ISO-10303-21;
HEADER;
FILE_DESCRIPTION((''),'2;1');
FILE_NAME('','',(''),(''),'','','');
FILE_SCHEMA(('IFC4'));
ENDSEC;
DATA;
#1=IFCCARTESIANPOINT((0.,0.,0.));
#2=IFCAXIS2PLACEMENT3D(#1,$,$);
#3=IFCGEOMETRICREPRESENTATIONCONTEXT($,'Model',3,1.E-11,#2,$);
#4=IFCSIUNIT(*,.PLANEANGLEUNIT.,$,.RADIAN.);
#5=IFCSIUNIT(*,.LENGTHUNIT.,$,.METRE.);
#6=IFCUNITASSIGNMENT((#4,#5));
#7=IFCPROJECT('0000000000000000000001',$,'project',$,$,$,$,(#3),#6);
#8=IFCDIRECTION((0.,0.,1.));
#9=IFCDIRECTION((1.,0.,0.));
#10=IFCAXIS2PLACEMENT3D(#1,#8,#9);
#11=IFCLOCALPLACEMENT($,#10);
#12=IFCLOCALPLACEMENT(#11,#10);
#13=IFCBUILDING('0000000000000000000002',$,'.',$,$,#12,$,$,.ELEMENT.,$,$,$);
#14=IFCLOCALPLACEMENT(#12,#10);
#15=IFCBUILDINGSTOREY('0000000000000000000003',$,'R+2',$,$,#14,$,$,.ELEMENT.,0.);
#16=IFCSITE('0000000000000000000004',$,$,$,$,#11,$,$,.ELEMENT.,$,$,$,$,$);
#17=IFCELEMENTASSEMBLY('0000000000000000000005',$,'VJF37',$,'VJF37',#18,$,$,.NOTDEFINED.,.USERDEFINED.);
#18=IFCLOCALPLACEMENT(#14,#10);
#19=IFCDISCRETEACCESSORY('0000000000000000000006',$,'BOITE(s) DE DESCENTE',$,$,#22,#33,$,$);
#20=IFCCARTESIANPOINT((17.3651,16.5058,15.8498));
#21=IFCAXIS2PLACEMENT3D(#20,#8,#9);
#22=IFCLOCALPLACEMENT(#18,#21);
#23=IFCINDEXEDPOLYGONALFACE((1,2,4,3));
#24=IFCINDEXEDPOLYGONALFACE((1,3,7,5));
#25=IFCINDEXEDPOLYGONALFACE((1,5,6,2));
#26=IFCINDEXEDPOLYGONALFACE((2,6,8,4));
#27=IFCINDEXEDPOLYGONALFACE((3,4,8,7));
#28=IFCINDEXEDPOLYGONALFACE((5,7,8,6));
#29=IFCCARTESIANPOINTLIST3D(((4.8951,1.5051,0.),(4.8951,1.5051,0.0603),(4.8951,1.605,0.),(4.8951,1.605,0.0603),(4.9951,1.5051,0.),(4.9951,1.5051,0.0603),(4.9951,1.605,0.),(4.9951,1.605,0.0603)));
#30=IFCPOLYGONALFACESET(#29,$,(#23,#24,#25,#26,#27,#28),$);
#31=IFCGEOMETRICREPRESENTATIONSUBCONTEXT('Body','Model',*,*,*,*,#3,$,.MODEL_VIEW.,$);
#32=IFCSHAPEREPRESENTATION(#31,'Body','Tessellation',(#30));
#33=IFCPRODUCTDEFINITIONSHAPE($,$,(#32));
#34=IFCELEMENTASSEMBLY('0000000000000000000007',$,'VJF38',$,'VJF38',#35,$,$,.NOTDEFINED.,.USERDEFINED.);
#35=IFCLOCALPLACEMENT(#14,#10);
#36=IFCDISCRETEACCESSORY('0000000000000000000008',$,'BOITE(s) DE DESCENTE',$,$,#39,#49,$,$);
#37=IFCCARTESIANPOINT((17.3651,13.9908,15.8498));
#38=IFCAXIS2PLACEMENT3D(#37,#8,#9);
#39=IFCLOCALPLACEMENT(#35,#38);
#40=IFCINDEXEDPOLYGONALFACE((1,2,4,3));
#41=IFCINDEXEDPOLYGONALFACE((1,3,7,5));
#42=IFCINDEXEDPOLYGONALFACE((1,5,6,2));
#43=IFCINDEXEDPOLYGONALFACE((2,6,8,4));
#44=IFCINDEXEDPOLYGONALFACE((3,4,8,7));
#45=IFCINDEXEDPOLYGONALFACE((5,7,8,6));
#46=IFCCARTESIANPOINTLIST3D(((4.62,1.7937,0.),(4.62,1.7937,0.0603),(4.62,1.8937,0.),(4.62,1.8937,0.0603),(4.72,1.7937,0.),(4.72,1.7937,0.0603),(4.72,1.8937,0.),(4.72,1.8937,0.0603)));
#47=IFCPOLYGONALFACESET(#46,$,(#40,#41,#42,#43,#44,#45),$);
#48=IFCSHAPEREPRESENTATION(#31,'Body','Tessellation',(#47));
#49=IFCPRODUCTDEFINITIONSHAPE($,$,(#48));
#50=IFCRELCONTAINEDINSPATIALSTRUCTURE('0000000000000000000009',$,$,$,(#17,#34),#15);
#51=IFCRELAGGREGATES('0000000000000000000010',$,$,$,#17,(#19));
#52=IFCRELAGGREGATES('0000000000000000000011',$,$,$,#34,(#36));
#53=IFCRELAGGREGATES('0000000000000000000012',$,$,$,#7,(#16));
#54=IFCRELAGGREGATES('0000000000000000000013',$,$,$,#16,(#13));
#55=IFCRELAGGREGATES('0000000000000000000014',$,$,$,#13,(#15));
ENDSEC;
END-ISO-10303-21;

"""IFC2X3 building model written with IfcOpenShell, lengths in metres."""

from ifc_helpers import new_model, si_unit, frame, origin, origin_with_axes, place, context, subcontext, project, spatial, polyline, outline, extrude, element, aggregate, save


model = new_model("IFC2X3")

# Units and contexts
model_context = context("Model", 3, precision=1e-11, world=origin())
body_context = subcontext(model_context, "Body", "Model", "MODEL_VIEW")
ifc_project = project(units=[si_unit("PLANEANGLEUNIT", "RADIAN"), si_unit("LENGTHUNIT", "METRE")], contexts=[model_context])

# Site, building, storey
site_placement = place(None, origin_with_axes())
site = spatial("IfcSite", under=ifc_project, at=site_placement, CompositionType="ELEMENT")
building_placement = place(site_placement, origin_with_axes())
building = spatial("IfcBuilding", under=site, at=building_placement, Name=".", CompositionType="ELEMENT")
storey_placement = place(building_placement, origin_with_axes())
storey = spatial("IfcBuildingStorey", under=building, at=storey_placement, Name="R+2", CompositionType="ELEMENT", Elevation=0.0)

# Element assembly
assembly_1_placement = place(storey_placement, origin_with_axes())
assembly_1 = element("IfcElementAssembly", 1, at=assembly_1_placement, inside=storey, Name="VJF37", ObjectType="VJF37", AssemblyPlace="NOTDEFINED", PredefinedType="USERDEFINED")

# Discrete accessory
discrete_accessory_1_placement = place(assembly_1_placement, frame((17.3651, 16.5058, 15.8498), z_axis=(0.0, 0.0, 1.0), x_axis=(1.0, 0.0, 0.0)))
discrete_accessory_1 = element("IfcDiscreteAccessory", 2, at=discrete_accessory_1_placement, Name="BOITE(s) DE DESCENTE", context=body_context, shape_type="SweptSolid", body=[
    extrude(outline(polyline([(1.505, -4.8951), (1.505, -4.9951), (1.6051, -4.9951), (1.6051, -4.8951), (1.505, -4.8951)])), frame((0.0, 0.0, 0.0), z_axis=(0.0, 0.0, 1.0), x_axis=(0.0, 1.0, 0.0)), (0.0, 0.0, 1.0), 0.0603),
])
aggregate(assembly_1, [discrete_accessory_1])

# Element assembly, discrete accessory
assembly_2_placement = place(storey_placement, origin_with_axes())
assembly_2 = element("IfcElementAssembly", 3, at=assembly_2_placement, inside=storey, Name="VJF38", ObjectType="VJF38", AssemblyPlace="NOTDEFINED", PredefinedType="USERDEFINED")
discrete_accessory_2_placement = place(assembly_2_placement, frame((17.3651, 13.9908, 15.8498), z_axis=(0.0, 0.0, 1.0), x_axis=(1.0, 0.0, 0.0)))
discrete_accessory_2 = element("IfcDiscreteAccessory", 4, at=discrete_accessory_2_placement, Name="BOITE(s) DE DESCENTE", context=body_context, shape_type="SweptSolid", body=[
    extrude(outline(polyline([(1.7937, -4.62), (1.7937, -4.72), (1.8937, -4.72), (1.8937, -4.62), (1.7937, -4.62)])), frame((0.0, 0.0, 0.0), z_axis=(0.0, 0.0, 1.0), x_axis=(0.0, 1.0, 0.0)), (0.0, 0.0, 1.0), 0.0603),
])
aggregate(assembly_2, [discrete_accessory_2])

save(model, "model.ifc")
